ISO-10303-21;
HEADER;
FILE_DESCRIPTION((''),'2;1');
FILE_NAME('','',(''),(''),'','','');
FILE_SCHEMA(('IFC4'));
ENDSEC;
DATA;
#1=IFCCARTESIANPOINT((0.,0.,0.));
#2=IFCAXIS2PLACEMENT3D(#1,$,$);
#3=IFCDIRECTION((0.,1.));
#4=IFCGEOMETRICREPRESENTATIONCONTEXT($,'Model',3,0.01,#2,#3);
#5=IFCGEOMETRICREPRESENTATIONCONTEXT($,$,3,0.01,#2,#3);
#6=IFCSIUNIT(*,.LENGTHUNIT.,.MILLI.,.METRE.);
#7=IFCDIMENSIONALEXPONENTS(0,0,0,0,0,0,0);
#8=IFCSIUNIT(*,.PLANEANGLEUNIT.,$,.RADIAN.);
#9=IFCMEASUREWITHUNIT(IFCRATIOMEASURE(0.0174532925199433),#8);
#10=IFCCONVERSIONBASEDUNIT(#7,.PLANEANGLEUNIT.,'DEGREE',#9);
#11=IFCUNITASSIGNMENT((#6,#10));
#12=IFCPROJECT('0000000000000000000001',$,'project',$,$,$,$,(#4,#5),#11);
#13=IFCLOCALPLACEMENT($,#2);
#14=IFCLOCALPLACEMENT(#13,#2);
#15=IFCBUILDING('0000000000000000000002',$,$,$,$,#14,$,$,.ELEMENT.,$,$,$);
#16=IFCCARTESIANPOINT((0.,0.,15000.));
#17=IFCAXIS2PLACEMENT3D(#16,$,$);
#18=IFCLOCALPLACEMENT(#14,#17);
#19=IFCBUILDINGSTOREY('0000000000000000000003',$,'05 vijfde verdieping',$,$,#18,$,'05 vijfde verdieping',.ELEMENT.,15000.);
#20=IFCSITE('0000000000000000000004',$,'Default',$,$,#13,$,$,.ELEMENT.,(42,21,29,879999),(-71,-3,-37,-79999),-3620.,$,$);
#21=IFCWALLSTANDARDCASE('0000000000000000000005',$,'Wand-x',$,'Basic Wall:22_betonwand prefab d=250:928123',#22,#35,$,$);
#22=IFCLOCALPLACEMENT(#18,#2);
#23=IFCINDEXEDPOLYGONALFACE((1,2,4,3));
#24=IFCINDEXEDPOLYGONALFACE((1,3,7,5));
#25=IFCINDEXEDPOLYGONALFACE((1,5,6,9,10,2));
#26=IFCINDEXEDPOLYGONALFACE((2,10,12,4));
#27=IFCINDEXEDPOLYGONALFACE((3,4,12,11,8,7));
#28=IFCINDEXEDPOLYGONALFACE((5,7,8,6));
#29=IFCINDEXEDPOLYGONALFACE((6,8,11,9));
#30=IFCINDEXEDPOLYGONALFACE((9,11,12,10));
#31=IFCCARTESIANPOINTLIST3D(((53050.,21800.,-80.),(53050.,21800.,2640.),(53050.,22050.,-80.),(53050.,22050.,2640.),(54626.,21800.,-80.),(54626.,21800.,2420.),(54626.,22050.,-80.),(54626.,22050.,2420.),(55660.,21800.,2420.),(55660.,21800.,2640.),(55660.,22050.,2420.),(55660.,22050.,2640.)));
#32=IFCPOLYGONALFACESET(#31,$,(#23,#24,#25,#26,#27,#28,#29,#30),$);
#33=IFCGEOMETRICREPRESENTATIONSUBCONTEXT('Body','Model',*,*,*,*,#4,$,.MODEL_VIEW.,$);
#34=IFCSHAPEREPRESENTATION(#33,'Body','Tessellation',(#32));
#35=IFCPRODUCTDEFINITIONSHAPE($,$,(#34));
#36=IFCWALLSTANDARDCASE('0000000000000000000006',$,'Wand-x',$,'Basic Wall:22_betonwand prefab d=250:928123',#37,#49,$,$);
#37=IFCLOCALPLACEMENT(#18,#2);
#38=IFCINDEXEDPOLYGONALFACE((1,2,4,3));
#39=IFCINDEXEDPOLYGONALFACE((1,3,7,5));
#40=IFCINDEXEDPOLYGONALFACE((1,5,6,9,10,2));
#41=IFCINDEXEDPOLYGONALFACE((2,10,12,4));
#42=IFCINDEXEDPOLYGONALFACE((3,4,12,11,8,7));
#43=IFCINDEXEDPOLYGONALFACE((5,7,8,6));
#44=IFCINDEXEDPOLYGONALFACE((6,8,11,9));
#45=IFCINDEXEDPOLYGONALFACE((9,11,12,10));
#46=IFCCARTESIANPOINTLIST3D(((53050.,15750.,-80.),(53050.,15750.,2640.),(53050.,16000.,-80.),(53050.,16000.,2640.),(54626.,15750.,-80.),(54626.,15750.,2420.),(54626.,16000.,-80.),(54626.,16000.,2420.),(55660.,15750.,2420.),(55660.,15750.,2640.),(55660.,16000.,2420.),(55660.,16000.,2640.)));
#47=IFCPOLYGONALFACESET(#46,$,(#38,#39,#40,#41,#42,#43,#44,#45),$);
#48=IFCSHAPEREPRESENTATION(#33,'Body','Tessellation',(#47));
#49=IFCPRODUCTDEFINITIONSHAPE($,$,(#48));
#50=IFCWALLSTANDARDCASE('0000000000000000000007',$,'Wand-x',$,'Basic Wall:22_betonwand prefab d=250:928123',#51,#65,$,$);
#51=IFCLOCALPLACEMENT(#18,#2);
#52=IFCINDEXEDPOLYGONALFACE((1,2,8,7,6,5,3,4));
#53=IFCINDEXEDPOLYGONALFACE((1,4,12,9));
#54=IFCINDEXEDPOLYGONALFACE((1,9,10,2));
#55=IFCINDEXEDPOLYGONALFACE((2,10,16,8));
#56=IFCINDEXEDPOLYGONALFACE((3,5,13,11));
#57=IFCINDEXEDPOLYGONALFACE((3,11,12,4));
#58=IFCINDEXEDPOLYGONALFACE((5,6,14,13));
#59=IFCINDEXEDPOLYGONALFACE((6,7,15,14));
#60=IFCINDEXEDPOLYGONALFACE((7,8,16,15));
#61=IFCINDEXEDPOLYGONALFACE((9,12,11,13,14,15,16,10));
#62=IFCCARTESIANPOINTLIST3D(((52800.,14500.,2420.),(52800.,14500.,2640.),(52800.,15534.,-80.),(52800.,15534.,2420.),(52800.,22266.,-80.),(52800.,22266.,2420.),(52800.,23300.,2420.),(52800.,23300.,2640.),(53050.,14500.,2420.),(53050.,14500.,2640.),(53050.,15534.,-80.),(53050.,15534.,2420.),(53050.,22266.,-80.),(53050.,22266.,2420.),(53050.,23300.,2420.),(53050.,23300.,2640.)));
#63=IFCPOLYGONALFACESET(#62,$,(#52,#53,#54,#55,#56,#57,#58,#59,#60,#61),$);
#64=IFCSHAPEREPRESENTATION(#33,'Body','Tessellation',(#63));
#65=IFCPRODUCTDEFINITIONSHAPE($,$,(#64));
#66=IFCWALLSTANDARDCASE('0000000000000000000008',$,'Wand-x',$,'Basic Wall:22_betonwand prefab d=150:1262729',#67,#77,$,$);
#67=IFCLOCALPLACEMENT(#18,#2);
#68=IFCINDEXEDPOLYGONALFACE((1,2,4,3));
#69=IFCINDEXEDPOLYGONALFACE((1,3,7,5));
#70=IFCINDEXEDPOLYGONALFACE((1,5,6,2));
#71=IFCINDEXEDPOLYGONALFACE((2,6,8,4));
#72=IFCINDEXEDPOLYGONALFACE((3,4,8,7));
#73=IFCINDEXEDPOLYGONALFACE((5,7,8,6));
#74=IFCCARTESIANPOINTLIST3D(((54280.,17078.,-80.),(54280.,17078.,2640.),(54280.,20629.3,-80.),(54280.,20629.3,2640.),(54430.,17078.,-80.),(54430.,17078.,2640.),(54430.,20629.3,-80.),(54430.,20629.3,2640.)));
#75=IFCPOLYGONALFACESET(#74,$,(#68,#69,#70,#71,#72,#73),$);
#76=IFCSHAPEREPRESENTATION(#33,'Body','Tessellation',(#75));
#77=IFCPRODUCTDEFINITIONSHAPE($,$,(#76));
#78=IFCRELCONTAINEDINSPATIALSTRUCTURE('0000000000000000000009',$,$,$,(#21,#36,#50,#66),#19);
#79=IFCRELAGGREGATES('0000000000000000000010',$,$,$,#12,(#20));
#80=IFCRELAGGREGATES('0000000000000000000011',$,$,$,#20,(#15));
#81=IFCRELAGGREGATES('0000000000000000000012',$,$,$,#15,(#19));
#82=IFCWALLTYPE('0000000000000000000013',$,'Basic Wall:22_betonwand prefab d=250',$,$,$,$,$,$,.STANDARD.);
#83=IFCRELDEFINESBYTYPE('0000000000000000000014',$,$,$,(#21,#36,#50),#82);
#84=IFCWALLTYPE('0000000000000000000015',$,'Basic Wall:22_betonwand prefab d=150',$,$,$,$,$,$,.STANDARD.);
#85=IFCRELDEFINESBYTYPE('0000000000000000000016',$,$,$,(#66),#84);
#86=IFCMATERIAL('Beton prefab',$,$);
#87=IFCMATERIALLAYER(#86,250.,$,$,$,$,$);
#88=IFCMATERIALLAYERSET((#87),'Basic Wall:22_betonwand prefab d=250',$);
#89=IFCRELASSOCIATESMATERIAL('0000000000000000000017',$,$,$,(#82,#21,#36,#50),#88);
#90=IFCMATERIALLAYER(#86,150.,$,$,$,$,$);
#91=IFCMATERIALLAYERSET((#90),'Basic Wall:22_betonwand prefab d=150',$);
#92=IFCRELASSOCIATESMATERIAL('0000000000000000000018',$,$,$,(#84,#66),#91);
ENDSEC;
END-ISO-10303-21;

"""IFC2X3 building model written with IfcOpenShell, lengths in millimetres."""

from ifc_helpers import new_model, entity, si_unit, converted_unit, direction, frame, frame_2d, origin, place, context, subcontext, project, spatial, rectangle, extrude, material, layer, layer_set, layer_usage, type_object, element, save


model = new_model("IFC2X3")

# Units and contexts
model_context = context("Model", 3, precision=0.01, world=origin(), true_north=direction((0.0, 1.0)))
context_of_model = context(None, 3, precision=0.01, world=origin(), true_north=direction((0.0, 1.0)))
body_context = subcontext(model_context, "Body", "Model", "MODEL_VIEW")
ifc_project = project(units=[si_unit("LENGTHUNIT", "METRE", prefix="MILLI"), converted_unit("PLANEANGLEUNIT", "DEGREE", entity("IfcRatioMeasure", 0.0174532925199433), si_unit("PLANEANGLEUNIT", "RADIAN"), dimensions=[0, 0, 0, 0, 0, 0, 0])], contexts=[model_context, context_of_model])

# Site, building, storey
site_placement = place(None, origin())
site = spatial("IfcSite", under=ifc_project, at=site_placement, Name="Default", CompositionType="ELEMENT", RefLatitude=(42, 21, 29, 879999), RefLongitude=(-71, -3, -37, -79999), RefElevation=-3620.0)
building_placement = place(site_placement, origin())
building = spatial("IfcBuilding", under=site, at=building_placement, CompositionType="ELEMENT")
storey_placement = place(building_placement, frame((0.0, 0.0, 15000.0)))
storey = spatial("IfcBuildingStorey", under=building, at=storey_placement, Name="05 vijfde verdieping", LongName="05 vijfde verdieping", CompositionType="ELEMENT", Elevation=15000.0)

# Shared definitions
ifc_material_1 = material(Name="Beton prefab")

# Walls, openings
ifc_layer_1 = layer(ifc_material_1, 250.0)
ifc_layer_set_1 = layer_set([ifc_layer_1], Name="Basic Wall:22_betonwand prefab d=250")
ifc_layer_usage_1 = layer_usage(ifc_layer_set_1, "AXIS2", "NEGATIVE", 125.0)
wall_type_1 = type_object("IfcWallType", Name="Basic Wall:22_betonwand prefab d=250", PredefinedType="STANDARD", material=ifc_layer_set_1)
wall_1_placement = place(storey_placement, frame((53050.0, 21925.0, -80.0)))
wall_1 = element("IfcWallStandardCase", 1, at=wall_1_placement, inside=storey, type_object=wall_type_1, material=ifc_layer_usage_1, Name="Wand-x", ObjectType="Basic Wall:22_betonwand prefab d=250:928123", context=body_context, shape_type="SweptSolid", body=[
    extrude(rectangle(XDim=2610.0, YDim=250.0, at=frame_2d((1305.0, 0.0), x_axis=(-1.0, 0.0))), origin(), (0.0, 0.0, 1.0), 2720.0),
])
opening_1_placement = place(wall_1_placement, frame((-53050.0, -21925.0, 80.0)))
element("IfcOpeningElement", 2, at=opening_1_placement, cuts=wall_1, ObjectType="Opening", context=body_context, shape_type="SweptSolid", body=[
    extrude(rectangle(XDim=2500.0, YDim=1034.0, at=frame_2d((0.0, 0.0), x_axis=(1.0, 0.0))), frame((55143.0, 21525.0, 1170.0), z_axis=(0.0, 1.0, 0.0), x_axis=(0.0, 0.0, -1.0)), (0.0, 0.0, 1.0), 800.0),
])
ifc_layer_usage_2 = layer_usage(ifc_layer_set_1, "AXIS2", "POSITIVE", -125.0)
wall_2_placement = place(storey_placement, frame((53050.0, 15875.0, -80.0)))
wall_2 = element("IfcWallStandardCase", 3, at=wall_2_placement, inside=storey, type_object=wall_type_1, material=ifc_layer_usage_2, Name="Wand-x", ObjectType="Basic Wall:22_betonwand prefab d=250:928123", context=body_context, shape_type="SweptSolid", body=[
    extrude(rectangle(XDim=2610.0, YDim=250.0, at=frame_2d((1305.0, 0.0), x_axis=(-1.0, 0.0))), origin(), (0.0, 0.0, 1.0), 2720.0),
])
opening_2_placement = place(wall_2_placement, frame((-53050.0, -15875.0, 80.0)))
element("IfcOpeningElement", 4, at=opening_2_placement, cuts=wall_2, ObjectType="Opening", context=body_context, shape_type="SweptSolid", body=[
    extrude(rectangle(XDim=2500.0, YDim=1034.0, at=frame_2d((0.0, 0.0), x_axis=(1.0, 0.0))), frame((55143.0, 15475.0, 1170.0), z_axis=(0.0, 1.0, 0.0), x_axis=(0.0, 0.0, -1.0)), (0.0, 0.0, 1.0), 800.0),
])

# Wall, openings
ifc_layer_usage_3 = layer_usage(ifc_layer_set_1, "AXIS2", "NEGATIVE", 125.0)
wall_3_placement = place(storey_placement, frame((52925.0, 14500.0, -80.0), z_axis=(0.0, 0.0, 1.0), x_axis=(0.0, 1.0, 0.0)))
wall_3 = element("IfcWallStandardCase", 5, at=wall_3_placement, inside=storey, type_object=wall_type_1, material=ifc_layer_usage_3, Name="Wand-x", ObjectType="Basic Wall:22_betonwand prefab d=250:928123", context=body_context, shape_type="SweptSolid", body=[
    extrude(rectangle(XDim=8800.0, YDim=250.0, at=frame_2d((4400.0, 0.0), x_axis=(-1.0, 0.0))), origin(), (0.0, 0.0, 1.0), 2720.0),
])
opening_3_placement = place(wall_3_placement, frame((-14500.0, 52925.0, 80.0), z_axis=(0.0, 0.0, 1.0), x_axis=(0.0, -1.0, 0.0)))
element("IfcOpeningElement", 6, at=opening_3_placement, cuts=wall_3, ObjectType="Opening", context=body_context, shape_type="SweptSolid", body=[
    extrude(rectangle(XDim=2500.0, YDim=1034.0, at=frame_2d((0.0, 0.0), x_axis=(1.0, 0.0))), frame((53325.0, 15017.0, 1170.0), z_axis=(-1.0, 0.0, 0.0), x_axis=(0.0, 0.0, -1.0)), (0.0, 0.0, 1.0), 800.0),
])
opening_4_placement = place(wall_3_placement, frame((-14500.0, 52925.0, 80.0), z_axis=(0.0, 0.0, 1.0), x_axis=(0.0, -1.0, 0.0)))
element("IfcOpeningElement", 7, at=opening_4_placement, cuts=wall_3, ObjectType="Opening", context=body_context, shape_type="SweptSolid", body=[
    extrude(rectangle(XDim=2500.0, YDim=1034.0, at=frame_2d((0.0, 0.0), x_axis=(0.0, 1.0))), frame((53325.0, 22783.0, 1170.0), z_axis=(-1.0, 0.0, 0.0), x_axis=(0.0, 1.0, 0.0)), (0.0, 0.0, 1.0), 800.0),
])

# Wall
ifc_layer_2 = layer(ifc_material_1, 150.0)
ifc_layer_set_2 = layer_set([ifc_layer_2], Name="Basic Wall:22_betonwand prefab d=150")
ifc_layer_usage_4 = layer_usage(ifc_layer_set_2, "AXIS2", "NEGATIVE", 75.0)
wall_type_2 = type_object("IfcWallType", Name="Basic Wall:22_betonwand prefab d=150", PredefinedType="STANDARD", material=ifc_layer_set_2)
wall_4_placement = place(storey_placement, frame((54355.0, 17078.0, -80.0), z_axis=(0.0, 0.0, 1.0), x_axis=(0.0, 1.0, 0.0)))
element("IfcWallStandardCase", 8, at=wall_4_placement, inside=storey, type_object=wall_type_2, material=ifc_layer_usage_4, Name="Wand-x", ObjectType="Basic Wall:22_betonwand prefab d=150:1262729", context=body_context, shape_type="SweptSolid", body=[
    extrude(rectangle(XDim=3551.3, YDim=150.0, at=frame_2d((1775.7, 0.0), x_axis=(-1.0, 0.0))), origin(), (0.0, 0.0, 1.0), 2720.0),
])

save(model, "model.ifc")
